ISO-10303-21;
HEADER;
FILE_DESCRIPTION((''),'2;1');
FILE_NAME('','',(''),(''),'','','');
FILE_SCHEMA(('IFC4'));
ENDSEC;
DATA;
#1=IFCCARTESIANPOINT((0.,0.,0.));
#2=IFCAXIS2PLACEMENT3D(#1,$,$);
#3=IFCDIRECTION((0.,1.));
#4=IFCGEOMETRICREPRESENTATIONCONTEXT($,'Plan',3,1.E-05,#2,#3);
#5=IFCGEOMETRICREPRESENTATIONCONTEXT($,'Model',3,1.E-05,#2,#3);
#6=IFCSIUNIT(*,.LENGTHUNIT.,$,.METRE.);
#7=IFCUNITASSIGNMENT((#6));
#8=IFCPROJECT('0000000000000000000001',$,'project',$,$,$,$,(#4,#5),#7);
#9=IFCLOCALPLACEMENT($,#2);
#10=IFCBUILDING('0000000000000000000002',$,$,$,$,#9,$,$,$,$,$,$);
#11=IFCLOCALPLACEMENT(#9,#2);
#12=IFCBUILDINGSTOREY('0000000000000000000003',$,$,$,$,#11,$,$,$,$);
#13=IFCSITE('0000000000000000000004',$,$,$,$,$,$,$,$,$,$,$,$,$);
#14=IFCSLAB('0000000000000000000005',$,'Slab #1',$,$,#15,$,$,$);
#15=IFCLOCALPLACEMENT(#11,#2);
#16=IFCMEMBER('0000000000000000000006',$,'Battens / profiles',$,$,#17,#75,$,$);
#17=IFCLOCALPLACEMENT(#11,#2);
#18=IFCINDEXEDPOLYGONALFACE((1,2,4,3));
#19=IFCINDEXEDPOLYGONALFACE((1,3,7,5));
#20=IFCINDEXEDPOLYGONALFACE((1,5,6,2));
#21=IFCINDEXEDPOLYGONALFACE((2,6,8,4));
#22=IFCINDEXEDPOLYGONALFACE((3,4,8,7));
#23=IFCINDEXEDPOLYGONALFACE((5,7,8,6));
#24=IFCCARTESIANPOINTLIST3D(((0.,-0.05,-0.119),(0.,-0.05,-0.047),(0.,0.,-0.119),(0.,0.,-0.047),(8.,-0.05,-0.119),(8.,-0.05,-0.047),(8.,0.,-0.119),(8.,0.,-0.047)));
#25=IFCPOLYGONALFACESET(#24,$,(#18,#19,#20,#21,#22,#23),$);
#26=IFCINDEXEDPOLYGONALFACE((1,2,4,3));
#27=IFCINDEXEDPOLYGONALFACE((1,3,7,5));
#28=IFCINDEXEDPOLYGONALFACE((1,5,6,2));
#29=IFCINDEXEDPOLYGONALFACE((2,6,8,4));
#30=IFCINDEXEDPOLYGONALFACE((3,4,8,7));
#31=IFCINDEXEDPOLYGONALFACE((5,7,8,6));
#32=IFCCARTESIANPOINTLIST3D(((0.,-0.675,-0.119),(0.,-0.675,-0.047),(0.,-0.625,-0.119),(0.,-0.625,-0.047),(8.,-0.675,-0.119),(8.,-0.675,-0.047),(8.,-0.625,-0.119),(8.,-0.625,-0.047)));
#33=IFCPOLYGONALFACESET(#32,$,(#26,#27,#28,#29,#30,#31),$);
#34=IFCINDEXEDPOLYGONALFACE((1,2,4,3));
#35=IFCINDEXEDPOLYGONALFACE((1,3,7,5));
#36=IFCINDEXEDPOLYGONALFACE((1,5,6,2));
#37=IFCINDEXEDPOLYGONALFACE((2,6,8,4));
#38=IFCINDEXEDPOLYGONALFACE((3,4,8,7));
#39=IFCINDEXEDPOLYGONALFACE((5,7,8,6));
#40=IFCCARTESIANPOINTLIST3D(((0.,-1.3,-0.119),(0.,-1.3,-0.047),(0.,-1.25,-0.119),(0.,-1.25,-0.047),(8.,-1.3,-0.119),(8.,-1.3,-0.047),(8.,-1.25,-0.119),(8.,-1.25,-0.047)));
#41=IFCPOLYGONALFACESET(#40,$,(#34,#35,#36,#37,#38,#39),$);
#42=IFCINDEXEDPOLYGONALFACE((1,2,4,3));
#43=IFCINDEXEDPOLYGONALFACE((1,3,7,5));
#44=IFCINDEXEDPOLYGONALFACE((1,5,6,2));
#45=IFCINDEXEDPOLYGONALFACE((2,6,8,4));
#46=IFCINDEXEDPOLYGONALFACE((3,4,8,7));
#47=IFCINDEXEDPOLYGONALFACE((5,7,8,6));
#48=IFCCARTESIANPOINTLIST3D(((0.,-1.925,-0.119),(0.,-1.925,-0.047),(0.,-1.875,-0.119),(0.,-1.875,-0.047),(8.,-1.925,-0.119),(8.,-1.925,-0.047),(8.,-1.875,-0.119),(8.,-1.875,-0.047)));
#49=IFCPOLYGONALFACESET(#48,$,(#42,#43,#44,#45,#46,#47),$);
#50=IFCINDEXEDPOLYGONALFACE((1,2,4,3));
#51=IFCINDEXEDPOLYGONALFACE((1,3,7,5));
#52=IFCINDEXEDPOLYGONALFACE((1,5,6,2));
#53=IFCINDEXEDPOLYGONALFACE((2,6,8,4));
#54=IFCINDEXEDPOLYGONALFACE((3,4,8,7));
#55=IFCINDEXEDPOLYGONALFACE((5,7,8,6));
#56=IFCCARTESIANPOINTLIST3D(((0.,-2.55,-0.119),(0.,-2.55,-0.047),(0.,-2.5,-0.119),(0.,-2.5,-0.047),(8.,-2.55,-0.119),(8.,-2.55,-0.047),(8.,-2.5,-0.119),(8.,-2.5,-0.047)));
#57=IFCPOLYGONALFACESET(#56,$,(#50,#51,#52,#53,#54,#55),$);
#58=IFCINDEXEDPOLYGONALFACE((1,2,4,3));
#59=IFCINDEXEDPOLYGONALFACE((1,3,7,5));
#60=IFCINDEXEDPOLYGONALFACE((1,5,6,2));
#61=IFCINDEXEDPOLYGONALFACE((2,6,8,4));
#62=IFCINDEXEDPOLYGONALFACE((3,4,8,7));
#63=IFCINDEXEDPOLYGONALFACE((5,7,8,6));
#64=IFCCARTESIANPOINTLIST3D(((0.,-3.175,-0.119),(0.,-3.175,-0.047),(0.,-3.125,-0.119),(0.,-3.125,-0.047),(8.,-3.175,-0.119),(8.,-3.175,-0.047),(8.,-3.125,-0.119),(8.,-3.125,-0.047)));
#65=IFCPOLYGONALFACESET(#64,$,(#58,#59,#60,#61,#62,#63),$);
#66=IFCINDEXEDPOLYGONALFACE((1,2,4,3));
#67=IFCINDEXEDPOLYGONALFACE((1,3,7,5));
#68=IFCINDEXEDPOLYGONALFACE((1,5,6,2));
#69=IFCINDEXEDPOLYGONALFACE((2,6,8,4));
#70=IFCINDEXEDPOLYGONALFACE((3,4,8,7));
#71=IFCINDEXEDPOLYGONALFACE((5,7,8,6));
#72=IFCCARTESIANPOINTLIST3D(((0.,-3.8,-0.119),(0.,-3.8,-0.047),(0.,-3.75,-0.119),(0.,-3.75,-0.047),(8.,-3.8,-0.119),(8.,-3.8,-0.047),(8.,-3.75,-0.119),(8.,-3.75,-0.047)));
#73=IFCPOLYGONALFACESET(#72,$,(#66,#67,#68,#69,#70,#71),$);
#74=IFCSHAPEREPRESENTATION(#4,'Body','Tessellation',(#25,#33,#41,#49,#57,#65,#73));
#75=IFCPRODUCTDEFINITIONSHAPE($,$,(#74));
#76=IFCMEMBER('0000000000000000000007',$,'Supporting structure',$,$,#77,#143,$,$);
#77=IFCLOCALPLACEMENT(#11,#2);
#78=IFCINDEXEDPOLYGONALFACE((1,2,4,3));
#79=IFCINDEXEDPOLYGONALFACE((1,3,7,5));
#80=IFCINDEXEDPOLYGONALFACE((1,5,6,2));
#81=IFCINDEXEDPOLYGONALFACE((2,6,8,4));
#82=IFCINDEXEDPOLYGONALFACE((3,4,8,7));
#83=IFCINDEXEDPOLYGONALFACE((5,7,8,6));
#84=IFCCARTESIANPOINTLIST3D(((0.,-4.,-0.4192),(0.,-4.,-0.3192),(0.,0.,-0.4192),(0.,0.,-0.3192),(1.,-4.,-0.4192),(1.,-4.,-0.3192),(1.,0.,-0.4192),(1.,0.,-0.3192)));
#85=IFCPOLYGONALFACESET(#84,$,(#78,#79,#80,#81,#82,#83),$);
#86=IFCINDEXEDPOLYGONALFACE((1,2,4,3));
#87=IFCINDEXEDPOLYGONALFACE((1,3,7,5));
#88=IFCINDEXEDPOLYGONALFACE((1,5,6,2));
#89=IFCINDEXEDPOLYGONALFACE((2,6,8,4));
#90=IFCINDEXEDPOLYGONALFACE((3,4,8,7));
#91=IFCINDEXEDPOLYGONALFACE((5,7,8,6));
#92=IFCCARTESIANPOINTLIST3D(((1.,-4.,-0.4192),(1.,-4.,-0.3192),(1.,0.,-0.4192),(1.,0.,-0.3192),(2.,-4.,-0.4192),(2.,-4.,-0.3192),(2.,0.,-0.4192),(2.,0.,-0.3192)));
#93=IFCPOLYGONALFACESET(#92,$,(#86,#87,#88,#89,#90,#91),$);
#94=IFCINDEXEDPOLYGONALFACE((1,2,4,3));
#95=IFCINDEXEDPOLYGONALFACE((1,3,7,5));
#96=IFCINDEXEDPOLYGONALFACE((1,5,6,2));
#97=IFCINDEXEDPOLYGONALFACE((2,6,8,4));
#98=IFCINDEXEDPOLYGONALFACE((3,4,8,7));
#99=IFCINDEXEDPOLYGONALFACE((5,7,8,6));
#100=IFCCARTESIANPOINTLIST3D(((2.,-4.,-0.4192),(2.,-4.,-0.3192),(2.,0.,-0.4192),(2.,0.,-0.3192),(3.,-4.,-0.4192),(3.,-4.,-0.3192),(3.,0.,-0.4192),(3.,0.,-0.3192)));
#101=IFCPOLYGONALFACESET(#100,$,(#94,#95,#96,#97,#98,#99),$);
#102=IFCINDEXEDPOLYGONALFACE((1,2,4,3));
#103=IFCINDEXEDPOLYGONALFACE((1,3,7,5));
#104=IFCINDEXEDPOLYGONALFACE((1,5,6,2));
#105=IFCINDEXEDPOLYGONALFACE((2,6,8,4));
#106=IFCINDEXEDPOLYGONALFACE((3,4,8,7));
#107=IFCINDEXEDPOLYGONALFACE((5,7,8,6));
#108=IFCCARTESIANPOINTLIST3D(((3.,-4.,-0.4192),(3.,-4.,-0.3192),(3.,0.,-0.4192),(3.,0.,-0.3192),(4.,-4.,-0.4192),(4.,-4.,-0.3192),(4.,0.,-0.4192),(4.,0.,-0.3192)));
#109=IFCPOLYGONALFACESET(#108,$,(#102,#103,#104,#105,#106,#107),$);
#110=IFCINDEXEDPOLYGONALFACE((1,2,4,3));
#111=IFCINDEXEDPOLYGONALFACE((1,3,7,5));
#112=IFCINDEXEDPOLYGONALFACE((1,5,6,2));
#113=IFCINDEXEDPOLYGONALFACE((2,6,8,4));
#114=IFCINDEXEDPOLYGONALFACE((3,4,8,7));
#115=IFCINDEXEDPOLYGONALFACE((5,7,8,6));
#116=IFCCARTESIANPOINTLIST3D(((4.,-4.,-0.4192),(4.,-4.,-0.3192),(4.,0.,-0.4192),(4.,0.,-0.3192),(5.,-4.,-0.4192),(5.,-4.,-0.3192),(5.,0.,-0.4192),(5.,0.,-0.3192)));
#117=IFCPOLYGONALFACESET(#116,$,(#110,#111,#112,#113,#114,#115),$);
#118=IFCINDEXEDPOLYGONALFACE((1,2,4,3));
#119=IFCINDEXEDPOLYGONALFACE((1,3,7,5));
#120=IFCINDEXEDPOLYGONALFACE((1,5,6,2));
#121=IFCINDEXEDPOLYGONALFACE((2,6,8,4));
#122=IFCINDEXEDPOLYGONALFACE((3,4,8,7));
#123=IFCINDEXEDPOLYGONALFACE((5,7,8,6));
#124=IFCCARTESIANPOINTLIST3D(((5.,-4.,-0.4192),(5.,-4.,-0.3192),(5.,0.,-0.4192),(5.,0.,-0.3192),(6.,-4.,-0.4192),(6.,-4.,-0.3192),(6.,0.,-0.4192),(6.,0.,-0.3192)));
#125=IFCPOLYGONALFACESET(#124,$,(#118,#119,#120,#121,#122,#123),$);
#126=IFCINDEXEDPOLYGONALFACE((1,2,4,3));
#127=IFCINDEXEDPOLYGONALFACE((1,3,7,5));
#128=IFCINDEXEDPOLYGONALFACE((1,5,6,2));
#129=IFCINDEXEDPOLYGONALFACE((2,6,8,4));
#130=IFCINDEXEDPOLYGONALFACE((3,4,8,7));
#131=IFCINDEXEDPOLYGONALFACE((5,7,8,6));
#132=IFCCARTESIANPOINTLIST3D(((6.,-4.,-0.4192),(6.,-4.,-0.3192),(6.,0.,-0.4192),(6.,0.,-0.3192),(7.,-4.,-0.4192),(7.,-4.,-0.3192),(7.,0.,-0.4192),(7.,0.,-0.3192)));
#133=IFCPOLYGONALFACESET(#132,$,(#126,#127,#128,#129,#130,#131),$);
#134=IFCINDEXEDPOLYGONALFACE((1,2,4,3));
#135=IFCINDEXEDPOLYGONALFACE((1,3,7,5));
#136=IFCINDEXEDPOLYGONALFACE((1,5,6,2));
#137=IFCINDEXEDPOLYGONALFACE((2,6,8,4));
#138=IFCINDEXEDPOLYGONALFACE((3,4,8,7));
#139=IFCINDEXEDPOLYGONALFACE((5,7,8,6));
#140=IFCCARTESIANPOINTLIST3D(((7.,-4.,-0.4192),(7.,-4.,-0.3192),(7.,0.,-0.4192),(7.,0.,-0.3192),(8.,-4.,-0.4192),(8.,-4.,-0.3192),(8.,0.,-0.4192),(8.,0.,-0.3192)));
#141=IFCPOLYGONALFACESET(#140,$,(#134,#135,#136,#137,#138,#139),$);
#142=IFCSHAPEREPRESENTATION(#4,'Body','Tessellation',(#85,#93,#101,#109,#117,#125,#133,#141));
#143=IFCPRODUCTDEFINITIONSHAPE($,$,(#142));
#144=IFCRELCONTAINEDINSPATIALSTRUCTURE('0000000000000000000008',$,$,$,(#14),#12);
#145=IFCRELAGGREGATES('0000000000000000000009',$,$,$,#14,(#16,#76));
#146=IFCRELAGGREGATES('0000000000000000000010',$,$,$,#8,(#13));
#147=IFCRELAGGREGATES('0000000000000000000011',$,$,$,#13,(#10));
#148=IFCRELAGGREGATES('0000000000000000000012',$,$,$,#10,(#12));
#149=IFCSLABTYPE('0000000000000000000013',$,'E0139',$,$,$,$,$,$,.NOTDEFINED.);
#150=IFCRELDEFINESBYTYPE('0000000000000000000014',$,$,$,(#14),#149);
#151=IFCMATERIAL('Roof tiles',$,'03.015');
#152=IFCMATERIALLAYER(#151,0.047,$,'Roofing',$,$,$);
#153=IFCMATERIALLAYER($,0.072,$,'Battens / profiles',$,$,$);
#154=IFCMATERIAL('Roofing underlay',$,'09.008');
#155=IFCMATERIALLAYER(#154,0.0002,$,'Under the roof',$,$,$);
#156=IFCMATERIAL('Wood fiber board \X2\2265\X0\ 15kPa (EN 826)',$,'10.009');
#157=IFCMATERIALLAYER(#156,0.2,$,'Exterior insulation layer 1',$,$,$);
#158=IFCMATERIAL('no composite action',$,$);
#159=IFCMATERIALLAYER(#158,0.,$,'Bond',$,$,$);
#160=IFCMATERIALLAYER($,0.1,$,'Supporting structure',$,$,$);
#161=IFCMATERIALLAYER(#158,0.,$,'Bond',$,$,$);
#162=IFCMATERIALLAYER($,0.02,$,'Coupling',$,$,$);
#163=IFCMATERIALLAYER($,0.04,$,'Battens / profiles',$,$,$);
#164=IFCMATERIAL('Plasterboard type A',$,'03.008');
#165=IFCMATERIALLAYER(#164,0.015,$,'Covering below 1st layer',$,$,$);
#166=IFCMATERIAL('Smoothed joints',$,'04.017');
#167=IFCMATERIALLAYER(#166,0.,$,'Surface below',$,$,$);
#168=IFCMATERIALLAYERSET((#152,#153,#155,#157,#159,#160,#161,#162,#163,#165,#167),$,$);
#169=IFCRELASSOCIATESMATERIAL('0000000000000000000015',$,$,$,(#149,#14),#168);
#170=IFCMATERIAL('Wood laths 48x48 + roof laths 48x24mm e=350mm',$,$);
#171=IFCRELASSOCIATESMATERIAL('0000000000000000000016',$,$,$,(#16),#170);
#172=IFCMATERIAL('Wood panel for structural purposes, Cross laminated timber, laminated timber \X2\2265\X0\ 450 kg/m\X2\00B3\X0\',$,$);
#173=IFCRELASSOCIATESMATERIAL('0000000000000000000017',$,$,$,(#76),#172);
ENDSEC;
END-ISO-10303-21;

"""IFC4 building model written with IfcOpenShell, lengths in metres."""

from ifc_helpers import new_model, si_unit, direction, frame, frame_2d, origin, place, context, project, spatial, rectangle, extrude, material, layer, layer_set, type_object, element, aggregate, save


model = new_model("IFC4")

# Units and contexts
plan_context = context("Plan", 3, precision=1e-05, world=origin(), true_north=direction((0.0, 1.0)))
model_context = context("Model", 3, precision=1e-05, world=origin(), true_north=direction((0.0, 1.0)))
ifc_project = project(units=[si_unit("LENGTHUNIT", "METRE")], contexts=[plan_context, model_context])

# Site, building, storey
site = spatial("IfcSite", under=ifc_project)
building_placement = place(None, origin())
building = spatial("IfcBuilding", under=site, at=building_placement)
storey_placement = place(building_placement, origin())
storey = spatial("IfcBuildingStorey", under=building, at=storey_placement)

# Slab, members
ifc_material_1 = material(Name="Roof tiles", Category="03.015")
ifc_layer_1 = layer(ifc_material_1, 0.047, Name="Roofing")
ifc_layer_2 = layer(None, 0.072, Name="Battens / profiles")
ifc_material_2 = material(Name="Roofing underlay", Category="09.008")
ifc_layer_3 = layer(ifc_material_2, 0.0002, Name="Under the roof")
ifc_material_3 = material(Name="Wood fiber board ≥ 15kPa (EN 826)", Category="10.009")
ifc_layer_4 = layer(ifc_material_3, 0.2, Name="Exterior insulation layer 1")
ifc_material_4 = material(Name="no composite action")
ifc_layer_5 = layer(ifc_material_4, 0.0, Name="Bond")
ifc_layer_6 = layer(None, 0.1, Name="Supporting structure")
ifc_layer_7 = layer(ifc_material_4, 0.0, Name="Bond")
ifc_layer_8 = layer(None, 0.02, Name="Coupling")
ifc_layer_9 = layer(None, 0.04, Name="Battens / profiles")
ifc_material_5 = material(Name="Plasterboard type A", Category="03.008")
ifc_layer_10 = layer(ifc_material_5, 0.015, Name="Covering below 1st layer")
ifc_material_6 = material(Name="Smoothed joints", Category="04.017")
ifc_layer_11 = layer(ifc_material_6, 0.0, Name="Surface below")
ifc_layer_set = layer_set([ifc_layer_1, ifc_layer_2, ifc_layer_3, ifc_layer_4, ifc_layer_5, ifc_layer_6, ifc_layer_7, ifc_layer_8, ifc_layer_9, ifc_layer_10, ifc_layer_11])
slab_type = type_object("IfcSlabType", Name="E0139", PredefinedType="NOTDEFINED", material=ifc_layer_set)
slab_placement = place(None, frame((0.0, 0.0, 0.0), z_axis=(0.0, 0.0, -1.0), x_axis=(1.0, 0.0, 0.0)))
slab = element("IfcSlab", 1, at=slab_placement, inside=storey, type_object=slab_type, material=ifc_layer_set, Name="Slab #1")
ifc_material_7 = material(Name="Wood laths 48x48 + roof laths 48x24mm e=350mm")
member_1_placement = place(slab_placement, origin())
member_1 = element("IfcMember", 2, at=member_1_placement, material=ifc_material_7, Name="Battens / profiles", context=plan_context, shape_type="SweptSolid", body=[
    extrude(rectangle(XDim=0.05, YDim=0.072, at=frame_2d((0.025, 0.036), x_axis=(1.0, 0.0))), frame((0.0, 0.0, 0.047), z_axis=(1.0, 0.0, 0.0), x_axis=(0.0, 1.0, 0.0)), (0.0, 0.0, 1.0), 8.0),
    extrude(rectangle(XDim=0.05, YDim=0.072, at=frame_2d((0.025, 0.036), x_axis=(1.0, 0.0))), frame((0.0, 0.625, 0.047), z_axis=(1.0, 0.0, 0.0), x_axis=(0.0, 1.0, 0.0)), (0.0, 0.0, 1.0), 8.0),
    extrude(rectangle(XDim=0.05, YDim=0.072, at=frame_2d((0.025, 0.036), x_axis=(1.0, 0.0))), frame((0.0, 1.25, 0.047), z_axis=(1.0, 0.0, 0.0), x_axis=(0.0, 1.0, 0.0)), (0.0, 0.0, 1.0), 8.0),
    extrude(rectangle(XDim=0.05, YDim=0.072, at=frame_2d((0.025, 0.036), x_axis=(1.0, 0.0))), frame((0.0, 1.875, 0.047), z_axis=(1.0, 0.0, 0.0), x_axis=(0.0, 1.0, 0.0)), (0.0, 0.0, 1.0), 8.0),
    extrude(rectangle(XDim=0.05, YDim=0.072, at=frame_2d((0.025, 0.036), x_axis=(1.0, 0.0))), frame((0.0, 2.5, 0.047), z_axis=(1.0, 0.0, 0.0), x_axis=(0.0, 1.0, 0.0)), (0.0, 0.0, 1.0), 8.0),
    extrude(rectangle(XDim=0.05, YDim=0.072, at=frame_2d((0.025, 0.036), x_axis=(1.0, 0.0))), frame((0.0, 3.125, 0.047), z_axis=(1.0, 0.0, 0.0), x_axis=(0.0, 1.0, 0.0)), (0.0, 0.0, 1.0), 8.0),
    extrude(rectangle(XDim=0.05, YDim=0.072, at=frame_2d((0.025, 0.036), x_axis=(1.0, 0.0))), frame((0.0, 3.75, 0.047), z_axis=(1.0, 0.0, 0.0), x_axis=(0.0, 1.0, 0.0)), (0.0, 0.0, 1.0), 8.0),
])
ifc_material_8 = material(Name="Wood panel for structural purposes, Cross laminated timber, laminated timber ≥ 450 kg/m³")
member_2_placement = place(slab_placement, origin())
member_2 = element("IfcMember", 3, at=member_2_placement, material=ifc_material_8, Name="Supporting structure", context=plan_context, shape_type="SweptSolid", body=[
    extrude(rectangle(XDim=1.0, YDim=0.1, at=frame_2d((0.5, 0.05), x_axis=(1.0, 0.0))), frame((0.0, 4.0, 0.3192), z_axis=(0.0, -1.0, 0.0), x_axis=(1.0, 0.0, 0.0)), (0.0, 0.0, 1.0), 4.0),
    extrude(rectangle(XDim=1.0, YDim=0.1, at=frame_2d((0.5, 0.05), x_axis=(1.0, 0.0))), frame((1.0, 4.0, 0.3192), z_axis=(0.0, -1.0, 0.0), x_axis=(1.0, 0.0, 0.0)), (0.0, 0.0, 1.0), 4.0),
    extrude(rectangle(XDim=1.0, YDim=0.1, at=frame_2d((0.5, 0.05), x_axis=(1.0, 0.0))), frame((2.0, 4.0, 0.3192), z_axis=(0.0, -1.0, 0.0), x_axis=(1.0, 0.0, 0.0)), (0.0, 0.0, 1.0), 4.0),
    extrude(rectangle(XDim=1.0, YDim=0.1, at=frame_2d((0.5, 0.05), x_axis=(1.0, 0.0))), frame((3.0, 4.0, 0.3192), z_axis=(0.0, -1.0, 0.0), x_axis=(1.0, 0.0, 0.0)), (0.0, 0.0, 1.0), 4.0),
    extrude(rectangle(XDim=1.0, YDim=0.1, at=frame_2d((0.5, 0.05), x_axis=(1.0, 0.0))), frame((4.0, 4.0, 0.3192), z_axis=(0.0, -1.0, 0.0), x_axis=(1.0, 0.0, 0.0)), (0.0, 0.0, 1.0), 4.0),
    extrude(rectangle(XDim=1.0, YDim=0.1, at=frame_2d((0.5, 0.05), x_axis=(1.0, 0.0))), frame((5.0, 4.0, 0.3192), z_axis=(0.0, -1.0, 0.0), x_axis=(1.0, 0.0, 0.0)), (0.0, 0.0, 1.0), 4.0),
    extrude(rectangle(XDim=1.0, YDim=0.1, at=frame_2d((0.5, 0.05), x_axis=(1.0, 0.0))), frame((6.0, 4.0, 0.3192), z_axis=(0.0, -1.0, 0.0), x_axis=(1.0, 0.0, 0.0)), (0.0, 0.0, 1.0), 4.0),
    extrude(rectangle(XDim=1.0, YDim=0.1, at=frame_2d((0.5, 0.05), x_axis=(1.0, 0.0))), frame((7.0, 4.0, 0.3192), z_axis=(0.0, -1.0, 0.0), x_axis=(1.0, 0.0, 0.0)), (0.0, 0.0, 1.0), 4.0),
])
aggregate(slab, [member_1, member_2])

save(model, "model.ifc")
